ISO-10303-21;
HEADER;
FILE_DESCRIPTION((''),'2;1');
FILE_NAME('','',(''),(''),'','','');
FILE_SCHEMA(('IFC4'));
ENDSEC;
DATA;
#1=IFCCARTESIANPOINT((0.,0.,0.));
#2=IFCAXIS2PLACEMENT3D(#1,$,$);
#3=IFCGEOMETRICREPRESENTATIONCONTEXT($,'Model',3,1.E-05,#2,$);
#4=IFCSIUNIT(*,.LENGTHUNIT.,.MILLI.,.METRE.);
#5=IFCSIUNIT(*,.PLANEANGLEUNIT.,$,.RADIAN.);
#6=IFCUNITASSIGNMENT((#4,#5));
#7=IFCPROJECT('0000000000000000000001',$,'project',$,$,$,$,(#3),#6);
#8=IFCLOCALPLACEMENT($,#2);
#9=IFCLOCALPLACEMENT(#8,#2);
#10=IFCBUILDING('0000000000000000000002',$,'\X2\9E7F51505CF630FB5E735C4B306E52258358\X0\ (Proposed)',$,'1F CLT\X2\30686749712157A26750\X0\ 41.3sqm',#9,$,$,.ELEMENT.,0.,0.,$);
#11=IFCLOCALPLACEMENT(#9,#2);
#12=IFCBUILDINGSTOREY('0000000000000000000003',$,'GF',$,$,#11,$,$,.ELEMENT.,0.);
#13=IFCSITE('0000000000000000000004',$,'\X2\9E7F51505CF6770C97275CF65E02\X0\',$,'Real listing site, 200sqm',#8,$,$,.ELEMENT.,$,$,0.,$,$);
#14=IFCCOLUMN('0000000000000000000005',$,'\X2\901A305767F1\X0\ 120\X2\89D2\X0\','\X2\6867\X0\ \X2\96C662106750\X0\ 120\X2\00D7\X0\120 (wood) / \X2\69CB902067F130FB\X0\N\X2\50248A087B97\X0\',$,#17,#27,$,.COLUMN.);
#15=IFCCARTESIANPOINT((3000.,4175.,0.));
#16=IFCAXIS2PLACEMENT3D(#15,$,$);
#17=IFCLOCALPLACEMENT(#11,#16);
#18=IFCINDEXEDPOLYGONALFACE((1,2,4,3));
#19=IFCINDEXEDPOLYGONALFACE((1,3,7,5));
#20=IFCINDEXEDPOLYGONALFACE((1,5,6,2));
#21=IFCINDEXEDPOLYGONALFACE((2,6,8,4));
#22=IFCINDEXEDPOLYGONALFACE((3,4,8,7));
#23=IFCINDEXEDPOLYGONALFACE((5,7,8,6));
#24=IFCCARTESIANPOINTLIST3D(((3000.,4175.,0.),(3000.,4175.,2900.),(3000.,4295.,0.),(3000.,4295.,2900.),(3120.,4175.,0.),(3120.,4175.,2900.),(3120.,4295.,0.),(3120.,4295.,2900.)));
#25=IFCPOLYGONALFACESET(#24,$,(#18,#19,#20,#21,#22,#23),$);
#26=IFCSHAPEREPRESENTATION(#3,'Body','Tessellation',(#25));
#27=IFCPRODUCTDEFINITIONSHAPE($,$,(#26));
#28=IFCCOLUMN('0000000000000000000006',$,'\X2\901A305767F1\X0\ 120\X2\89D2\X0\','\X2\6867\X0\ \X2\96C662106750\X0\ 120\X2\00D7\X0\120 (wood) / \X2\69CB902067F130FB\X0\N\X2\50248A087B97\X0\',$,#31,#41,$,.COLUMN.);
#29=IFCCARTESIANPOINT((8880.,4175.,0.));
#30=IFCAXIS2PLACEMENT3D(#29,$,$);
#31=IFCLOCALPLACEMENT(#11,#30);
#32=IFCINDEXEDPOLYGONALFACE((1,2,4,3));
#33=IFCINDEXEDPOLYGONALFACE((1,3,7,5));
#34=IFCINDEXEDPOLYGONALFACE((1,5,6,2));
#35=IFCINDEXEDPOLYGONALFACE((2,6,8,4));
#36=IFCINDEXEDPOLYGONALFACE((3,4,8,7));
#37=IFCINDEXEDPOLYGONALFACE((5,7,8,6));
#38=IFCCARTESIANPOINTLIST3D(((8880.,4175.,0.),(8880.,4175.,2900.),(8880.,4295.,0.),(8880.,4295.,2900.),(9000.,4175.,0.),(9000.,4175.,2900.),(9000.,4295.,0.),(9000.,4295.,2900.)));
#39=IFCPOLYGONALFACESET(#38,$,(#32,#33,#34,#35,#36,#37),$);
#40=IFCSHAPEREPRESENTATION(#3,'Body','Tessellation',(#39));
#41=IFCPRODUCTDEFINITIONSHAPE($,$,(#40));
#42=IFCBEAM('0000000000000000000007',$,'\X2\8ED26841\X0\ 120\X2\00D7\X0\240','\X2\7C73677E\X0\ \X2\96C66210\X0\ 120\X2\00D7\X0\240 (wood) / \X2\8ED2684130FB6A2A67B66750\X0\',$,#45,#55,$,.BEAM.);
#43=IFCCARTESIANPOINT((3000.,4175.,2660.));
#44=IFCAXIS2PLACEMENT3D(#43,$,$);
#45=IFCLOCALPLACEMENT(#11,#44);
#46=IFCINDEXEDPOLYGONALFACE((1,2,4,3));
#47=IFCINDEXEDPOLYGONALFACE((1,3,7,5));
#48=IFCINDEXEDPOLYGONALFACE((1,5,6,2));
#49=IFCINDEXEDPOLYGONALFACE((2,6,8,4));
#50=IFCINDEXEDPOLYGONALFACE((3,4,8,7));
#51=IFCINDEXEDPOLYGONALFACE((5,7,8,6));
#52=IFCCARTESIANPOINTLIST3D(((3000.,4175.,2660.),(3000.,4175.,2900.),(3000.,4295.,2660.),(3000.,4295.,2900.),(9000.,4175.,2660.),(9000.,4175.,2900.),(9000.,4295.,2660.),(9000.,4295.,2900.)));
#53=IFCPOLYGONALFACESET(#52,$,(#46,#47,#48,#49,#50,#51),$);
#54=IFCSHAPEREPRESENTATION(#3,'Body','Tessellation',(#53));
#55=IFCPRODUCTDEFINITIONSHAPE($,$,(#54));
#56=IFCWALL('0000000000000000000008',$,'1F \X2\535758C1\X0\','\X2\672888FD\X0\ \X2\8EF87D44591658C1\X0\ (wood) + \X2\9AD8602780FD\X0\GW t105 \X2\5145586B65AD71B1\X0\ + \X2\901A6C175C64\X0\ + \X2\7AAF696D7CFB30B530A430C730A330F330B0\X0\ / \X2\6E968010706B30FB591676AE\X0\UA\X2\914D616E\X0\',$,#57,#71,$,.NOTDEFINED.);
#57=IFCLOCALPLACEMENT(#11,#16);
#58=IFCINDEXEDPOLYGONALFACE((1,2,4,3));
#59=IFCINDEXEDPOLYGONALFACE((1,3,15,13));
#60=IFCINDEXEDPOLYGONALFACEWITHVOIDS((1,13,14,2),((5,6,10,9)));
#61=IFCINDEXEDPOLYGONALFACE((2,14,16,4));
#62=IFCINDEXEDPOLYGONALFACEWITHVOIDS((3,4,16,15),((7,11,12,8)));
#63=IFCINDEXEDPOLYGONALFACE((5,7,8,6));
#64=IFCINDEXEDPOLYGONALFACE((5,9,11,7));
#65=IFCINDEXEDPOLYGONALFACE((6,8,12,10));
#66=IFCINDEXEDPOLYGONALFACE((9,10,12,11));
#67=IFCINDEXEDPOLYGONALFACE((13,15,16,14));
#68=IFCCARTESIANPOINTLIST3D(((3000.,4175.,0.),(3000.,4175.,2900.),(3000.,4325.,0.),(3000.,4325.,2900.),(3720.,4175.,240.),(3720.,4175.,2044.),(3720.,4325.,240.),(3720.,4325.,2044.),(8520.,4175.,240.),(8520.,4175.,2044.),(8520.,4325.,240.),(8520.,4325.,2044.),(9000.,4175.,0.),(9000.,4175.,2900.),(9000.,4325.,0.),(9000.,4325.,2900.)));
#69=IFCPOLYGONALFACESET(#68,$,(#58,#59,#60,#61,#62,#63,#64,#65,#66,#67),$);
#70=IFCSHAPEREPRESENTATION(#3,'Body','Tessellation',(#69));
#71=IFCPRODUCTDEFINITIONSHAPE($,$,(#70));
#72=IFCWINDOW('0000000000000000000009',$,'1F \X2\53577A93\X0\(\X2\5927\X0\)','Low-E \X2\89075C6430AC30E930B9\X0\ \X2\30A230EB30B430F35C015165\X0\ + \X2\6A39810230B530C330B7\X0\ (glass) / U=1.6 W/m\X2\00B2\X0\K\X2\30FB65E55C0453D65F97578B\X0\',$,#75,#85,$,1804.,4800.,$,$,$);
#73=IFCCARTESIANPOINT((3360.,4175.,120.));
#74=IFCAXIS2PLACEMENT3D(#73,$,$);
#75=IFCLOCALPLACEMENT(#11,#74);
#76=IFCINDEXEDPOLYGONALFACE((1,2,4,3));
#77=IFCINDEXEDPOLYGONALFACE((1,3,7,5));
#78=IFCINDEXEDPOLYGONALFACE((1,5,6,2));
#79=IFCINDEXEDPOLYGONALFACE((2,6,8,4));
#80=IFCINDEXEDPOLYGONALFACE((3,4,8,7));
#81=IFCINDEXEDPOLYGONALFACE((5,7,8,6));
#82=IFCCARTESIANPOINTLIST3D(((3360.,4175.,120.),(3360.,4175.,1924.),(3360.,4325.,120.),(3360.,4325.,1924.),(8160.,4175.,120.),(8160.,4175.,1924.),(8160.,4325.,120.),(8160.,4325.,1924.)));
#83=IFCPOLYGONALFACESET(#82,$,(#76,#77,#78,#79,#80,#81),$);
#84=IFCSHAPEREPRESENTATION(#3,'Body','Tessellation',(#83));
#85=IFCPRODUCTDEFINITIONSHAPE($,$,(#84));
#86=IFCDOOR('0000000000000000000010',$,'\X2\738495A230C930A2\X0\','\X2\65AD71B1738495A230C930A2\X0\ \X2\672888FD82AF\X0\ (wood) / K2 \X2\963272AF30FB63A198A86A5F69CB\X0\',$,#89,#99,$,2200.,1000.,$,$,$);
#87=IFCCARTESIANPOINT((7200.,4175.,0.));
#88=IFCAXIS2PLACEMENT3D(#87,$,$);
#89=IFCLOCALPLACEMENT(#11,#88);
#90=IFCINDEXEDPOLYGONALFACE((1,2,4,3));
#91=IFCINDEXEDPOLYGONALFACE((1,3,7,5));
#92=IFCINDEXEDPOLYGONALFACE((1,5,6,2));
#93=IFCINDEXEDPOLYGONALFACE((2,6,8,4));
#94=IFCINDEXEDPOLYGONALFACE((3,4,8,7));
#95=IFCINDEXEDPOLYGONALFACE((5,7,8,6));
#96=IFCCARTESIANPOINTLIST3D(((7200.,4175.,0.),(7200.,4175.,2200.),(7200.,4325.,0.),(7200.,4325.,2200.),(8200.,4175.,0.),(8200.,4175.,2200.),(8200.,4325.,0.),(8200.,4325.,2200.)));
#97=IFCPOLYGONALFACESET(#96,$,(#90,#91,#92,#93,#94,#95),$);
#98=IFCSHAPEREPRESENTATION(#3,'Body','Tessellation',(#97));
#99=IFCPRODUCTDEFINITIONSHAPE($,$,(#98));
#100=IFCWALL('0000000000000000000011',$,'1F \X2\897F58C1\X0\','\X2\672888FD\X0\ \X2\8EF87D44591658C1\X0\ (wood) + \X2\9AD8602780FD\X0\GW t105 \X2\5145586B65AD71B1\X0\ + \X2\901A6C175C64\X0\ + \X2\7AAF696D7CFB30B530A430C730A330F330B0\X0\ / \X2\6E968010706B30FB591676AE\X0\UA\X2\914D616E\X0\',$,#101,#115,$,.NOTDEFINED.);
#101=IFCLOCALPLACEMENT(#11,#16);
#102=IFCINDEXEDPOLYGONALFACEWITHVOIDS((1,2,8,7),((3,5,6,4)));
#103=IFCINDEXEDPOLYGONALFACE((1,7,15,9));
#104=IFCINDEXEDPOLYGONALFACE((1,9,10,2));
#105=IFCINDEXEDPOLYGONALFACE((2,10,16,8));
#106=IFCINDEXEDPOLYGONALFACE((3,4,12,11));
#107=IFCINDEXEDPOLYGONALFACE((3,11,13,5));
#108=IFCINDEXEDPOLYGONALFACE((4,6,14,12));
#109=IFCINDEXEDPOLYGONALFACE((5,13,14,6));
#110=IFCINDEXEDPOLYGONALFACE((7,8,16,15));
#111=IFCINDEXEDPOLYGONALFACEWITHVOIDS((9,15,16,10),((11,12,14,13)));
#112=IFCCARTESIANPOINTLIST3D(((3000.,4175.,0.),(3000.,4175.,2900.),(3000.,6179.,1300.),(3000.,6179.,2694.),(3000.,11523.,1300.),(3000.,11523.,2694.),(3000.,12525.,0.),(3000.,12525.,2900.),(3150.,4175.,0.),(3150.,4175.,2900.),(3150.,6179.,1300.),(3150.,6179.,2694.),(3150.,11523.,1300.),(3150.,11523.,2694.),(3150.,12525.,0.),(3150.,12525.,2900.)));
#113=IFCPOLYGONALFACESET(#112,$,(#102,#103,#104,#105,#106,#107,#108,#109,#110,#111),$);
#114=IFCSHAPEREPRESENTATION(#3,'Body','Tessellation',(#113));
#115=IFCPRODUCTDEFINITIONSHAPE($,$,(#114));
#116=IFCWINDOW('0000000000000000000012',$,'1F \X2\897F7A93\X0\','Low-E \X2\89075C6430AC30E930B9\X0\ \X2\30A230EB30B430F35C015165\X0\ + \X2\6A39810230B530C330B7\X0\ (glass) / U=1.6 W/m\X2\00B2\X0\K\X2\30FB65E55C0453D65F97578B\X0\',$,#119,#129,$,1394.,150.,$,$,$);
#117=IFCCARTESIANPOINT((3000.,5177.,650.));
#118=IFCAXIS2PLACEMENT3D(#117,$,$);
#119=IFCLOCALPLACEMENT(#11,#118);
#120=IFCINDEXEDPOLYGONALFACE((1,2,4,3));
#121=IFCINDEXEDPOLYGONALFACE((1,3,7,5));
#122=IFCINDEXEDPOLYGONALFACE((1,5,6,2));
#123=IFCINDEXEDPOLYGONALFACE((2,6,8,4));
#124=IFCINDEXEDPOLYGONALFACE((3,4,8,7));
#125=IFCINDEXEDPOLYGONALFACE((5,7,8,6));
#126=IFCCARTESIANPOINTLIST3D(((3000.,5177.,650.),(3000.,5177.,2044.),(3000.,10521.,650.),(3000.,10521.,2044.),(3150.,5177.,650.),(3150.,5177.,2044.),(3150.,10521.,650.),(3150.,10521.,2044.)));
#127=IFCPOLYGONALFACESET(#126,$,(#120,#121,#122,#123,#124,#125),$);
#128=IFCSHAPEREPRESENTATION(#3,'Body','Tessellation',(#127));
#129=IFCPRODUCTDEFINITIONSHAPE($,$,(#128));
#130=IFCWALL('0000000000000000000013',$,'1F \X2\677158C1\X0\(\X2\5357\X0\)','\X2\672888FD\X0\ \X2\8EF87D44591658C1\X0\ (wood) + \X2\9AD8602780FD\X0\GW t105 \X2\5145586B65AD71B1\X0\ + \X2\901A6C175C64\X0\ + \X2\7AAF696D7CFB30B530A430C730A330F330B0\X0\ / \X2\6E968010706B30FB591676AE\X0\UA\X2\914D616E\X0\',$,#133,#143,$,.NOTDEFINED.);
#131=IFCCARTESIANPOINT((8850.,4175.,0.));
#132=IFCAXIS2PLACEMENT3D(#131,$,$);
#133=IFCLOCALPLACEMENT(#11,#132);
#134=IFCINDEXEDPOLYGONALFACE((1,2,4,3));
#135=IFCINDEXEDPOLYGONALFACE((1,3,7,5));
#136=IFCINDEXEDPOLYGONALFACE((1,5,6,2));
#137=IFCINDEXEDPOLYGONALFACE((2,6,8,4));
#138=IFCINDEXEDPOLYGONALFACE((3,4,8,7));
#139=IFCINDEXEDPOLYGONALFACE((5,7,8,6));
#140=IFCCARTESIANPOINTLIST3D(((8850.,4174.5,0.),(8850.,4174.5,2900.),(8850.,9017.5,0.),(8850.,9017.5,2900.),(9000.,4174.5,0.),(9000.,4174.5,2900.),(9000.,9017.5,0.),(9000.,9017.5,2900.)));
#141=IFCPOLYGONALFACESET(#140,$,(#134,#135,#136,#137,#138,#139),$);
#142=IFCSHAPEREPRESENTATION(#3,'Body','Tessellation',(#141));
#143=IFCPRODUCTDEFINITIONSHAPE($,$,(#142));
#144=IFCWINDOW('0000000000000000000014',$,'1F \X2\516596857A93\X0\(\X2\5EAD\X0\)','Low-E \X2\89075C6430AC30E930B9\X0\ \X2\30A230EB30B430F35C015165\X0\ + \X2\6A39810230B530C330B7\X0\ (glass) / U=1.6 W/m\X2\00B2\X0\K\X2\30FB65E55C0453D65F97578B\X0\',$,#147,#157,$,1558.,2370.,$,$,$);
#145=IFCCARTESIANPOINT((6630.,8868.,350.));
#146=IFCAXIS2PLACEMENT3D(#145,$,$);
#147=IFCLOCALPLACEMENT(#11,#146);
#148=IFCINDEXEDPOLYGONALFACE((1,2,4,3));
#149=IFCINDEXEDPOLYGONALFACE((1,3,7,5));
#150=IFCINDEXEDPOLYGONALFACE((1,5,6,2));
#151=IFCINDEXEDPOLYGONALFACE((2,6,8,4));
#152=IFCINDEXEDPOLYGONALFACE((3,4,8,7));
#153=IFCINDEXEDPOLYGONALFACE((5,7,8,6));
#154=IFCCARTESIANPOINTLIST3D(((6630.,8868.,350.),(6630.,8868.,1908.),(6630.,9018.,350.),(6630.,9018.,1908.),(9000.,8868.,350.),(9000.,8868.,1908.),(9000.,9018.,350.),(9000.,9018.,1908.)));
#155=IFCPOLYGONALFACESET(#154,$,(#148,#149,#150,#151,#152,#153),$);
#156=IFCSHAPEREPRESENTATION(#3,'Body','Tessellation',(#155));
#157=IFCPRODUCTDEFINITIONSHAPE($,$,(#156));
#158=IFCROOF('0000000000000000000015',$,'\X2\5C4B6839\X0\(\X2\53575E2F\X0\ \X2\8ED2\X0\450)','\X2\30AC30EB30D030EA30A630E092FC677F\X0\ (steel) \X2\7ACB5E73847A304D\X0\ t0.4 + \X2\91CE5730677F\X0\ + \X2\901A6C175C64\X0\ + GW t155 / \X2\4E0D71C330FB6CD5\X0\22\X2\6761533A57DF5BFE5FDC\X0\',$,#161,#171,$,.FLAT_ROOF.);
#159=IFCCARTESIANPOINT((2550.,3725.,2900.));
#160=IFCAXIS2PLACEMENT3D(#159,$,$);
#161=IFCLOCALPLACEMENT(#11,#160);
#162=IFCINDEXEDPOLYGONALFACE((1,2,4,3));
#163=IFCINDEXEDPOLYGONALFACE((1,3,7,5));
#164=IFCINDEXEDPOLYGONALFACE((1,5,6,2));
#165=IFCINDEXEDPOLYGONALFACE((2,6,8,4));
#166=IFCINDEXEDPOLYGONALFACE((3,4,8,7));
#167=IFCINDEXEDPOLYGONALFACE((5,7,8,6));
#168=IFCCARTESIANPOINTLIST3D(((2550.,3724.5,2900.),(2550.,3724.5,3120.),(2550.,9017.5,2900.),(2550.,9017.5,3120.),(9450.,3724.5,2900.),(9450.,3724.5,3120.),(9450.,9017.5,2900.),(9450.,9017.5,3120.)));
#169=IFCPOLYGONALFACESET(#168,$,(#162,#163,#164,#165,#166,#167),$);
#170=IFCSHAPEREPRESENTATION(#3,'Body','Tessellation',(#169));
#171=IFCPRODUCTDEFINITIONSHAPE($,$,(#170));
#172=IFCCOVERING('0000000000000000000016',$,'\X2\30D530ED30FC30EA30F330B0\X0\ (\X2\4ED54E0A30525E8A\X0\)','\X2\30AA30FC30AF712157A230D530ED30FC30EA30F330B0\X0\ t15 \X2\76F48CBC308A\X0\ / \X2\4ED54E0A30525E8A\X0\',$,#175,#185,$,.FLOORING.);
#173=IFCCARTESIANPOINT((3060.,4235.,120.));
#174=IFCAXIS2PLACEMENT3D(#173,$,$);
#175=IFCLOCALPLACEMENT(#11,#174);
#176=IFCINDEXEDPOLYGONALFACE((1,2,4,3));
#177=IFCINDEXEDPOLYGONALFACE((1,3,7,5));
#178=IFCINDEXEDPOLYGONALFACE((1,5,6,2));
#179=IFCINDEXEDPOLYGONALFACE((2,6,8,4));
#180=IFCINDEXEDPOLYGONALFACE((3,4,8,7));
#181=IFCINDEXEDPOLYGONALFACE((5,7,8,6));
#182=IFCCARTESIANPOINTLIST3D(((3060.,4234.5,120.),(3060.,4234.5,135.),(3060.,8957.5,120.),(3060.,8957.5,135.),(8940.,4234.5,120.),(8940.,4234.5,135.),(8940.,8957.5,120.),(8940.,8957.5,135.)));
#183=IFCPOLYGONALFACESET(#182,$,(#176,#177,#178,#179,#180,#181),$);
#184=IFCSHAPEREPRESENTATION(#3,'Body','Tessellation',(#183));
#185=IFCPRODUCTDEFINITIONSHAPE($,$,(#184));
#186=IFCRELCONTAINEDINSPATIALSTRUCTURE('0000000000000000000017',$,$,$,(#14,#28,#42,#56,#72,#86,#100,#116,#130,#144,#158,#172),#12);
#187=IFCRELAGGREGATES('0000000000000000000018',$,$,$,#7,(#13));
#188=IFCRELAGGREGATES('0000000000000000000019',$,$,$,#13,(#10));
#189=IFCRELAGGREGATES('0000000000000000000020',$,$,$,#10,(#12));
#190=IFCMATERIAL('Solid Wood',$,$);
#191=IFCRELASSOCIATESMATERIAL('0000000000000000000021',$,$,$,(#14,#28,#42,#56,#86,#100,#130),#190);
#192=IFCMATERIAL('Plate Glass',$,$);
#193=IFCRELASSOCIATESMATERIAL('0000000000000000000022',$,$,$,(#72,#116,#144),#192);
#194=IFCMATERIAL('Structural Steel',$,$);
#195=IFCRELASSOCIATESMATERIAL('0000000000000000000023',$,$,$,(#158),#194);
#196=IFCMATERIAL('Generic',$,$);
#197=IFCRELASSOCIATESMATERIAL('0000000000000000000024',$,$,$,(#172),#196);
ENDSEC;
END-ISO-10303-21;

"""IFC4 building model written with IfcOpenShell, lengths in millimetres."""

from ifc_helpers import new_model, si_unit, frame, frame_2d, origin, place, context, project, spatial, rectangle, extrude, material, element, fill, save


model = new_model("IFC4")

# Units and contexts
model_context = context("Model", 3, precision=1e-05, world=origin())
ifc_project = project(units=[si_unit("LENGTHUNIT", "METRE", prefix="MILLI"), si_unit("PLANEANGLEUNIT", "RADIAN")], contexts=[model_context])

# Site, building, storey
site_placement = place(None, origin())
site = spatial("IfcSite", under=ifc_project, at=site_placement, Name="鹿児島県霧島市", ObjectType="Real listing site, 200sqm", CompositionType="ELEMENT", RefElevation=0.0)
building_placement = place(site_placement, origin())
building = spatial("IfcBuilding", under=site, at=building_placement, Name="鹿児島・平屋の別荘 (Proposed)", ObjectType="1F CLTと杉無垢材 41.3sqm", CompositionType="ELEMENT", ElevationOfRefHeight=0.0, ElevationOfTerrain=0.0)
storey_placement = place(building_placement, origin())
storey = spatial("IfcBuildingStorey", under=building, at=storey_placement, Name="GF", CompositionType="ELEMENT", Elevation=0.0)

# Columns
ifc_material_1 = material(Name="Solid Wood")
column_1_placement = place(storey_placement, frame((3000.0, 4175.0, 0.0)))
element("IfcColumn", 1, at=column_1_placement, inside=storey, material=ifc_material_1, Name="通し柱 120角", Description="桧 集成材 120×120 (wood) / 構造柱・N値計算", PredefinedType="COLUMN", context=model_context, shape_type="SweptSolid", body=[
    extrude(rectangle(XDim=120.0, YDim=120.0, at=frame_2d((60.0, 60.0))), frame((3000.0, 4175.0, 0.0)), (0.0, 0.0, 1.0), 2900.0),
])
column_2_placement = place(storey_placement, frame((8880.0, 4175.0, 0.0)))
element("IfcColumn", 2, at=column_2_placement, inside=storey, material=ifc_material_1, Name="通し柱 120角", Description="桧 集成材 120×120 (wood) / 構造柱・N値計算", PredefinedType="COLUMN", context=model_context, shape_type="SweptSolid", body=[
    extrude(rectangle(XDim=120.0, YDim=120.0, at=frame_2d((60.0, 60.0))), frame((8880.0, 4175.0, 0.0)), (0.0, 0.0, 1.0), 2900.0),
])

# Beam
beam_1_placement = place(storey_placement, frame((3000.0, 4175.0, 2660.0)))
element("IfcBeam", 3, at=beam_1_placement, inside=storey, material=ifc_material_1, Name="軒桁 120×240", Description="米松 集成 120×240 (wood) / 軒桁・横架材", PredefinedType="BEAM", context=model_context, shape_type="SweptSolid", body=[
    extrude(rectangle(XDim=6000.0, YDim=120.0, at=frame_2d((3000.0, 60.0))), frame((3000.0, 4175.0, 2660.0)), (0.0, 0.0, 1.0), 240.0),
])

# Wall, openings, window, door
wall_1_placement = place(storey_placement, frame((3000.0, 4175.0, 0.0)))
wall_1 = element("IfcWall", 4, at=wall_1_placement, inside=storey, material=ifc_material_1, Name="1F 南壁", Description="木製 軸組外壁 (wood) + 高性能GW t105 充填断熱 + 通気層 + 窯業系サイディング / 準耐火・外皮UA配慮", PredefinedType="NOTDEFINED", context=model_context, shape_type="SweptSolid", body=[
    extrude(rectangle(XDim=6000.0, YDim=150.0, at=frame_2d((3000.0, 75.0))), frame((3000.0, 4175.0, 0.0)), (0.0, 0.0, 1.0), 2900.0),
])
opening_1_placement = place(storey_placement, frame((3360.0, 4175.0, 120.0)))
opening_1 = element("IfcOpeningElement", 5, at=opening_1_placement, cuts=wall_1, PredefinedType="NOTDEFINED", context=model_context, shape_type="SweptSolid", body=[
    extrude(rectangle(XDim=4800.0, YDim=150.0, at=frame_2d((2400.0, 75.0))), frame((3360.0, 4175.0, 120.0)), (0.0, 0.0, 1.0), 1804.0),
])
opening_2_placement = place(storey_placement, frame((7200.0, 4175.0, 0.0)))
opening_2 = element("IfcOpeningElement", 6, at=opening_2_placement, cuts=wall_1, PredefinedType="NOTDEFINED", context=model_context, shape_type="SweptSolid", body=[
    extrude(rectangle(XDim=1000.0, YDim=150.0, at=frame_2d((500.0, 75.0))), frame((7200.0, 4175.0, 0.0)), (0.0, 0.0, 1.0), 2200.0),
])
ifc_material_2 = material(Name="Plate Glass")
window_1_placement = place(storey_placement, frame((3360.0, 4175.0, 120.0)))
window_1 = element("IfcWindow", 7, at=window_1_placement, inside=storey, material=ifc_material_2, Name="1F 南窓(大)", Description="Low-E 複層ガラス アルゴン封入 + 樹脂サッシ (glass) / U=1.6 W/m²K・日射取得型", OverallHeight=1804.0, OverallWidth=4800.0, context=model_context, shape_type="SweptSolid", body=[
    extrude(rectangle(XDim=4800.0, YDim=150.0, at=frame_2d((2400.0, 75.0))), frame((3360.0, 4175.0, 120.0)), (0.0, 0.0, 1.0), 1804.0),
])
fill(opening_1, window_1)
door_1_placement = place(storey_placement, frame((7200.0, 4175.0, 0.0)))
door_1 = element("IfcDoor", 8, at=door_1_placement, inside=storey, material=ifc_material_1, Name="玄関ドア", Description="断熱玄関ドア 木製芯 (wood) / K2 防犯・採風機構", OverallHeight=2200.0, OverallWidth=1000.0, context=model_context, shape_type="SweptSolid", body=[
    extrude(rectangle(XDim=1000.0, YDim=150.0, at=frame_2d((500.0, 75.0))), frame((7200.0, 4175.0, 0.0)), (0.0, 0.0, 1.0), 2200.0),
])
fill(opening_2, door_1)

# Walls, openings, windows
wall_2_placement = place(storey_placement, frame((3000.0, 4175.0, 0.0)))
wall_2 = element("IfcWall", 9, at=wall_2_placement, inside=storey, material=ifc_material_1, Name="1F 西壁", Description="木製 軸組外壁 (wood) + 高性能GW t105 充填断熱 + 通気層 + 窯業系サイディング / 準耐火・外皮UA配慮", PredefinedType="NOTDEFINED", context=model_context, shape_type="SweptSolid", body=[
    extrude(rectangle(XDim=150.0, YDim=8350.0, at=frame_2d((75.0, 4175.0))), frame((3000.0, 4175.0, 0.0)), (0.0, 0.0, 1.0), 2900.0),
])
opening_3_placement = place(storey_placement, frame((3000.0, 5177.0, 650.0)))
opening_3 = element("IfcOpeningElement", 10, at=opening_3_placement, cuts=wall_2, PredefinedType="NOTDEFINED", context=model_context, shape_type="SweptSolid", body=[
    extrude(rectangle(XDim=150.0, YDim=5344.0, at=frame_2d((75.0, 2672.0))), frame((3000.0, 5177.0, 650.0)), (0.0, 0.0, 1.0), 1394.0),
])
window_2_placement = place(storey_placement, frame((3000.0, 5177.0, 650.0)))
window_2 = element("IfcWindow", 11, at=window_2_placement, inside=storey, material=ifc_material_2, Name="1F 西窓", Description="Low-E 複層ガラス アルゴン封入 + 樹脂サッシ (glass) / U=1.6 W/m²K・日射取得型", OverallHeight=1394.0, OverallWidth=150.0, context=model_context, shape_type="SweptSolid", body=[
    extrude(rectangle(XDim=150.0, YDim=5344.0, at=frame_2d((75.0, 2672.0))), frame((3000.0, 5177.0, 650.0)), (0.0, 0.0, 1.0), 1394.0),
])
fill(opening_3, window_2)
wall_3_placement = place(storey_placement, frame((8850.0, 4175.0, 0.0)))
wall_3 = element("IfcWall", 12, at=wall_3_placement, inside=storey, material=ifc_material_1, Name="1F 東壁(南)", Description="木製 軸組外壁 (wood) + 高性能GW t105 充填断熱 + 通気層 + 窯業系サイディング / 準耐火・外皮UA配慮", PredefinedType="NOTDEFINED", context=model_context, shape_type="SweptSolid", body=[
    extrude(rectangle(XDim=150.0, YDim=4843.0, at=frame_2d((75.0, 2421.0))), frame((8850.0, 4175.0, 0.0)), (0.0, 0.0, 1.0), 2900.0),
])
opening_4_placement = place(storey_placement, frame((6630.0, 8868.0, 350.0)))
opening_4 = element("IfcOpeningElement", 13, at=opening_4_placement, cuts=wall_3, PredefinedType="NOTDEFINED", context=model_context, shape_type="SweptSolid", body=[
    extrude(rectangle(XDim=2370.0, YDim=150.0, at=frame_2d((1185.0, 75.0))), frame((6630.0, 8868.0, 350.0)), (0.0, 0.0, 1.0), 1558.0),
])
window_3_placement = place(storey_placement, frame((6630.0, 8868.0, 350.0)))
window_3 = element("IfcWindow", 14, at=window_3_placement, inside=storey, material=ifc_material_2, Name="1F 入隅窓(庭)", Description="Low-E 複層ガラス アルゴン封入 + 樹脂サッシ (glass) / U=1.6 W/m²K・日射取得型", OverallHeight=1558.0, OverallWidth=2370.0, context=model_context, shape_type="SweptSolid", body=[
    extrude(rectangle(XDim=2370.0, YDim=150.0, at=frame_2d((1185.0, 75.0))), frame((6630.0, 8868.0, 350.0)), (0.0, 0.0, 1.0), 1558.0),
])
fill(opening_4, window_3)

# Roof
ifc_material_3 = material(Name="Structural Steel")
roof_placement = place(storey_placement, frame((2550.0, 3725.0, 2900.0)))
element("IfcRoof", 15, at=roof_placement, inside=storey, material=ifc_material_3, Name="屋根(南帯 軒450)", Description="ガルバリウム鋼板 (steel) 立平葺き t0.4 + 野地板 + 通気層 + GW t155 / 不燃・法22条区域対応", PredefinedType="FLAT_ROOF", context=model_context, shape_type="SweptSolid", body=[
    extrude(rectangle(XDim=6900.0, YDim=5293.0, at=frame_2d((3450.0, 2646.0))), frame((2550.0, 3725.0, 2900.0)), (0.0, 0.0, 1.0), 220.0),
])

# Covering
ifc_material_4 = material(Name="Generic")
covering_1_placement = place(storey_placement, frame((3060.0, 4235.0, 120.0)))
element("IfcCovering", 16, at=covering_1_placement, inside=storey, material=ifc_material_4, Name="フローリング (仕上げ床)", Description="オーク無垢フローリング t15 直貼り / 仕上げ床", PredefinedType="FLOORING", context=model_context, shape_type="SweptSolid", body=[
    extrude(rectangle(XDim=5880.0, YDim=4723.0, at=frame_2d((2940.0, 2361.0))), frame((3060.0, 4235.0, 120.0)), (0.0, 0.0, 1.0), 15.0),
])

save(model, "model.ifc")
